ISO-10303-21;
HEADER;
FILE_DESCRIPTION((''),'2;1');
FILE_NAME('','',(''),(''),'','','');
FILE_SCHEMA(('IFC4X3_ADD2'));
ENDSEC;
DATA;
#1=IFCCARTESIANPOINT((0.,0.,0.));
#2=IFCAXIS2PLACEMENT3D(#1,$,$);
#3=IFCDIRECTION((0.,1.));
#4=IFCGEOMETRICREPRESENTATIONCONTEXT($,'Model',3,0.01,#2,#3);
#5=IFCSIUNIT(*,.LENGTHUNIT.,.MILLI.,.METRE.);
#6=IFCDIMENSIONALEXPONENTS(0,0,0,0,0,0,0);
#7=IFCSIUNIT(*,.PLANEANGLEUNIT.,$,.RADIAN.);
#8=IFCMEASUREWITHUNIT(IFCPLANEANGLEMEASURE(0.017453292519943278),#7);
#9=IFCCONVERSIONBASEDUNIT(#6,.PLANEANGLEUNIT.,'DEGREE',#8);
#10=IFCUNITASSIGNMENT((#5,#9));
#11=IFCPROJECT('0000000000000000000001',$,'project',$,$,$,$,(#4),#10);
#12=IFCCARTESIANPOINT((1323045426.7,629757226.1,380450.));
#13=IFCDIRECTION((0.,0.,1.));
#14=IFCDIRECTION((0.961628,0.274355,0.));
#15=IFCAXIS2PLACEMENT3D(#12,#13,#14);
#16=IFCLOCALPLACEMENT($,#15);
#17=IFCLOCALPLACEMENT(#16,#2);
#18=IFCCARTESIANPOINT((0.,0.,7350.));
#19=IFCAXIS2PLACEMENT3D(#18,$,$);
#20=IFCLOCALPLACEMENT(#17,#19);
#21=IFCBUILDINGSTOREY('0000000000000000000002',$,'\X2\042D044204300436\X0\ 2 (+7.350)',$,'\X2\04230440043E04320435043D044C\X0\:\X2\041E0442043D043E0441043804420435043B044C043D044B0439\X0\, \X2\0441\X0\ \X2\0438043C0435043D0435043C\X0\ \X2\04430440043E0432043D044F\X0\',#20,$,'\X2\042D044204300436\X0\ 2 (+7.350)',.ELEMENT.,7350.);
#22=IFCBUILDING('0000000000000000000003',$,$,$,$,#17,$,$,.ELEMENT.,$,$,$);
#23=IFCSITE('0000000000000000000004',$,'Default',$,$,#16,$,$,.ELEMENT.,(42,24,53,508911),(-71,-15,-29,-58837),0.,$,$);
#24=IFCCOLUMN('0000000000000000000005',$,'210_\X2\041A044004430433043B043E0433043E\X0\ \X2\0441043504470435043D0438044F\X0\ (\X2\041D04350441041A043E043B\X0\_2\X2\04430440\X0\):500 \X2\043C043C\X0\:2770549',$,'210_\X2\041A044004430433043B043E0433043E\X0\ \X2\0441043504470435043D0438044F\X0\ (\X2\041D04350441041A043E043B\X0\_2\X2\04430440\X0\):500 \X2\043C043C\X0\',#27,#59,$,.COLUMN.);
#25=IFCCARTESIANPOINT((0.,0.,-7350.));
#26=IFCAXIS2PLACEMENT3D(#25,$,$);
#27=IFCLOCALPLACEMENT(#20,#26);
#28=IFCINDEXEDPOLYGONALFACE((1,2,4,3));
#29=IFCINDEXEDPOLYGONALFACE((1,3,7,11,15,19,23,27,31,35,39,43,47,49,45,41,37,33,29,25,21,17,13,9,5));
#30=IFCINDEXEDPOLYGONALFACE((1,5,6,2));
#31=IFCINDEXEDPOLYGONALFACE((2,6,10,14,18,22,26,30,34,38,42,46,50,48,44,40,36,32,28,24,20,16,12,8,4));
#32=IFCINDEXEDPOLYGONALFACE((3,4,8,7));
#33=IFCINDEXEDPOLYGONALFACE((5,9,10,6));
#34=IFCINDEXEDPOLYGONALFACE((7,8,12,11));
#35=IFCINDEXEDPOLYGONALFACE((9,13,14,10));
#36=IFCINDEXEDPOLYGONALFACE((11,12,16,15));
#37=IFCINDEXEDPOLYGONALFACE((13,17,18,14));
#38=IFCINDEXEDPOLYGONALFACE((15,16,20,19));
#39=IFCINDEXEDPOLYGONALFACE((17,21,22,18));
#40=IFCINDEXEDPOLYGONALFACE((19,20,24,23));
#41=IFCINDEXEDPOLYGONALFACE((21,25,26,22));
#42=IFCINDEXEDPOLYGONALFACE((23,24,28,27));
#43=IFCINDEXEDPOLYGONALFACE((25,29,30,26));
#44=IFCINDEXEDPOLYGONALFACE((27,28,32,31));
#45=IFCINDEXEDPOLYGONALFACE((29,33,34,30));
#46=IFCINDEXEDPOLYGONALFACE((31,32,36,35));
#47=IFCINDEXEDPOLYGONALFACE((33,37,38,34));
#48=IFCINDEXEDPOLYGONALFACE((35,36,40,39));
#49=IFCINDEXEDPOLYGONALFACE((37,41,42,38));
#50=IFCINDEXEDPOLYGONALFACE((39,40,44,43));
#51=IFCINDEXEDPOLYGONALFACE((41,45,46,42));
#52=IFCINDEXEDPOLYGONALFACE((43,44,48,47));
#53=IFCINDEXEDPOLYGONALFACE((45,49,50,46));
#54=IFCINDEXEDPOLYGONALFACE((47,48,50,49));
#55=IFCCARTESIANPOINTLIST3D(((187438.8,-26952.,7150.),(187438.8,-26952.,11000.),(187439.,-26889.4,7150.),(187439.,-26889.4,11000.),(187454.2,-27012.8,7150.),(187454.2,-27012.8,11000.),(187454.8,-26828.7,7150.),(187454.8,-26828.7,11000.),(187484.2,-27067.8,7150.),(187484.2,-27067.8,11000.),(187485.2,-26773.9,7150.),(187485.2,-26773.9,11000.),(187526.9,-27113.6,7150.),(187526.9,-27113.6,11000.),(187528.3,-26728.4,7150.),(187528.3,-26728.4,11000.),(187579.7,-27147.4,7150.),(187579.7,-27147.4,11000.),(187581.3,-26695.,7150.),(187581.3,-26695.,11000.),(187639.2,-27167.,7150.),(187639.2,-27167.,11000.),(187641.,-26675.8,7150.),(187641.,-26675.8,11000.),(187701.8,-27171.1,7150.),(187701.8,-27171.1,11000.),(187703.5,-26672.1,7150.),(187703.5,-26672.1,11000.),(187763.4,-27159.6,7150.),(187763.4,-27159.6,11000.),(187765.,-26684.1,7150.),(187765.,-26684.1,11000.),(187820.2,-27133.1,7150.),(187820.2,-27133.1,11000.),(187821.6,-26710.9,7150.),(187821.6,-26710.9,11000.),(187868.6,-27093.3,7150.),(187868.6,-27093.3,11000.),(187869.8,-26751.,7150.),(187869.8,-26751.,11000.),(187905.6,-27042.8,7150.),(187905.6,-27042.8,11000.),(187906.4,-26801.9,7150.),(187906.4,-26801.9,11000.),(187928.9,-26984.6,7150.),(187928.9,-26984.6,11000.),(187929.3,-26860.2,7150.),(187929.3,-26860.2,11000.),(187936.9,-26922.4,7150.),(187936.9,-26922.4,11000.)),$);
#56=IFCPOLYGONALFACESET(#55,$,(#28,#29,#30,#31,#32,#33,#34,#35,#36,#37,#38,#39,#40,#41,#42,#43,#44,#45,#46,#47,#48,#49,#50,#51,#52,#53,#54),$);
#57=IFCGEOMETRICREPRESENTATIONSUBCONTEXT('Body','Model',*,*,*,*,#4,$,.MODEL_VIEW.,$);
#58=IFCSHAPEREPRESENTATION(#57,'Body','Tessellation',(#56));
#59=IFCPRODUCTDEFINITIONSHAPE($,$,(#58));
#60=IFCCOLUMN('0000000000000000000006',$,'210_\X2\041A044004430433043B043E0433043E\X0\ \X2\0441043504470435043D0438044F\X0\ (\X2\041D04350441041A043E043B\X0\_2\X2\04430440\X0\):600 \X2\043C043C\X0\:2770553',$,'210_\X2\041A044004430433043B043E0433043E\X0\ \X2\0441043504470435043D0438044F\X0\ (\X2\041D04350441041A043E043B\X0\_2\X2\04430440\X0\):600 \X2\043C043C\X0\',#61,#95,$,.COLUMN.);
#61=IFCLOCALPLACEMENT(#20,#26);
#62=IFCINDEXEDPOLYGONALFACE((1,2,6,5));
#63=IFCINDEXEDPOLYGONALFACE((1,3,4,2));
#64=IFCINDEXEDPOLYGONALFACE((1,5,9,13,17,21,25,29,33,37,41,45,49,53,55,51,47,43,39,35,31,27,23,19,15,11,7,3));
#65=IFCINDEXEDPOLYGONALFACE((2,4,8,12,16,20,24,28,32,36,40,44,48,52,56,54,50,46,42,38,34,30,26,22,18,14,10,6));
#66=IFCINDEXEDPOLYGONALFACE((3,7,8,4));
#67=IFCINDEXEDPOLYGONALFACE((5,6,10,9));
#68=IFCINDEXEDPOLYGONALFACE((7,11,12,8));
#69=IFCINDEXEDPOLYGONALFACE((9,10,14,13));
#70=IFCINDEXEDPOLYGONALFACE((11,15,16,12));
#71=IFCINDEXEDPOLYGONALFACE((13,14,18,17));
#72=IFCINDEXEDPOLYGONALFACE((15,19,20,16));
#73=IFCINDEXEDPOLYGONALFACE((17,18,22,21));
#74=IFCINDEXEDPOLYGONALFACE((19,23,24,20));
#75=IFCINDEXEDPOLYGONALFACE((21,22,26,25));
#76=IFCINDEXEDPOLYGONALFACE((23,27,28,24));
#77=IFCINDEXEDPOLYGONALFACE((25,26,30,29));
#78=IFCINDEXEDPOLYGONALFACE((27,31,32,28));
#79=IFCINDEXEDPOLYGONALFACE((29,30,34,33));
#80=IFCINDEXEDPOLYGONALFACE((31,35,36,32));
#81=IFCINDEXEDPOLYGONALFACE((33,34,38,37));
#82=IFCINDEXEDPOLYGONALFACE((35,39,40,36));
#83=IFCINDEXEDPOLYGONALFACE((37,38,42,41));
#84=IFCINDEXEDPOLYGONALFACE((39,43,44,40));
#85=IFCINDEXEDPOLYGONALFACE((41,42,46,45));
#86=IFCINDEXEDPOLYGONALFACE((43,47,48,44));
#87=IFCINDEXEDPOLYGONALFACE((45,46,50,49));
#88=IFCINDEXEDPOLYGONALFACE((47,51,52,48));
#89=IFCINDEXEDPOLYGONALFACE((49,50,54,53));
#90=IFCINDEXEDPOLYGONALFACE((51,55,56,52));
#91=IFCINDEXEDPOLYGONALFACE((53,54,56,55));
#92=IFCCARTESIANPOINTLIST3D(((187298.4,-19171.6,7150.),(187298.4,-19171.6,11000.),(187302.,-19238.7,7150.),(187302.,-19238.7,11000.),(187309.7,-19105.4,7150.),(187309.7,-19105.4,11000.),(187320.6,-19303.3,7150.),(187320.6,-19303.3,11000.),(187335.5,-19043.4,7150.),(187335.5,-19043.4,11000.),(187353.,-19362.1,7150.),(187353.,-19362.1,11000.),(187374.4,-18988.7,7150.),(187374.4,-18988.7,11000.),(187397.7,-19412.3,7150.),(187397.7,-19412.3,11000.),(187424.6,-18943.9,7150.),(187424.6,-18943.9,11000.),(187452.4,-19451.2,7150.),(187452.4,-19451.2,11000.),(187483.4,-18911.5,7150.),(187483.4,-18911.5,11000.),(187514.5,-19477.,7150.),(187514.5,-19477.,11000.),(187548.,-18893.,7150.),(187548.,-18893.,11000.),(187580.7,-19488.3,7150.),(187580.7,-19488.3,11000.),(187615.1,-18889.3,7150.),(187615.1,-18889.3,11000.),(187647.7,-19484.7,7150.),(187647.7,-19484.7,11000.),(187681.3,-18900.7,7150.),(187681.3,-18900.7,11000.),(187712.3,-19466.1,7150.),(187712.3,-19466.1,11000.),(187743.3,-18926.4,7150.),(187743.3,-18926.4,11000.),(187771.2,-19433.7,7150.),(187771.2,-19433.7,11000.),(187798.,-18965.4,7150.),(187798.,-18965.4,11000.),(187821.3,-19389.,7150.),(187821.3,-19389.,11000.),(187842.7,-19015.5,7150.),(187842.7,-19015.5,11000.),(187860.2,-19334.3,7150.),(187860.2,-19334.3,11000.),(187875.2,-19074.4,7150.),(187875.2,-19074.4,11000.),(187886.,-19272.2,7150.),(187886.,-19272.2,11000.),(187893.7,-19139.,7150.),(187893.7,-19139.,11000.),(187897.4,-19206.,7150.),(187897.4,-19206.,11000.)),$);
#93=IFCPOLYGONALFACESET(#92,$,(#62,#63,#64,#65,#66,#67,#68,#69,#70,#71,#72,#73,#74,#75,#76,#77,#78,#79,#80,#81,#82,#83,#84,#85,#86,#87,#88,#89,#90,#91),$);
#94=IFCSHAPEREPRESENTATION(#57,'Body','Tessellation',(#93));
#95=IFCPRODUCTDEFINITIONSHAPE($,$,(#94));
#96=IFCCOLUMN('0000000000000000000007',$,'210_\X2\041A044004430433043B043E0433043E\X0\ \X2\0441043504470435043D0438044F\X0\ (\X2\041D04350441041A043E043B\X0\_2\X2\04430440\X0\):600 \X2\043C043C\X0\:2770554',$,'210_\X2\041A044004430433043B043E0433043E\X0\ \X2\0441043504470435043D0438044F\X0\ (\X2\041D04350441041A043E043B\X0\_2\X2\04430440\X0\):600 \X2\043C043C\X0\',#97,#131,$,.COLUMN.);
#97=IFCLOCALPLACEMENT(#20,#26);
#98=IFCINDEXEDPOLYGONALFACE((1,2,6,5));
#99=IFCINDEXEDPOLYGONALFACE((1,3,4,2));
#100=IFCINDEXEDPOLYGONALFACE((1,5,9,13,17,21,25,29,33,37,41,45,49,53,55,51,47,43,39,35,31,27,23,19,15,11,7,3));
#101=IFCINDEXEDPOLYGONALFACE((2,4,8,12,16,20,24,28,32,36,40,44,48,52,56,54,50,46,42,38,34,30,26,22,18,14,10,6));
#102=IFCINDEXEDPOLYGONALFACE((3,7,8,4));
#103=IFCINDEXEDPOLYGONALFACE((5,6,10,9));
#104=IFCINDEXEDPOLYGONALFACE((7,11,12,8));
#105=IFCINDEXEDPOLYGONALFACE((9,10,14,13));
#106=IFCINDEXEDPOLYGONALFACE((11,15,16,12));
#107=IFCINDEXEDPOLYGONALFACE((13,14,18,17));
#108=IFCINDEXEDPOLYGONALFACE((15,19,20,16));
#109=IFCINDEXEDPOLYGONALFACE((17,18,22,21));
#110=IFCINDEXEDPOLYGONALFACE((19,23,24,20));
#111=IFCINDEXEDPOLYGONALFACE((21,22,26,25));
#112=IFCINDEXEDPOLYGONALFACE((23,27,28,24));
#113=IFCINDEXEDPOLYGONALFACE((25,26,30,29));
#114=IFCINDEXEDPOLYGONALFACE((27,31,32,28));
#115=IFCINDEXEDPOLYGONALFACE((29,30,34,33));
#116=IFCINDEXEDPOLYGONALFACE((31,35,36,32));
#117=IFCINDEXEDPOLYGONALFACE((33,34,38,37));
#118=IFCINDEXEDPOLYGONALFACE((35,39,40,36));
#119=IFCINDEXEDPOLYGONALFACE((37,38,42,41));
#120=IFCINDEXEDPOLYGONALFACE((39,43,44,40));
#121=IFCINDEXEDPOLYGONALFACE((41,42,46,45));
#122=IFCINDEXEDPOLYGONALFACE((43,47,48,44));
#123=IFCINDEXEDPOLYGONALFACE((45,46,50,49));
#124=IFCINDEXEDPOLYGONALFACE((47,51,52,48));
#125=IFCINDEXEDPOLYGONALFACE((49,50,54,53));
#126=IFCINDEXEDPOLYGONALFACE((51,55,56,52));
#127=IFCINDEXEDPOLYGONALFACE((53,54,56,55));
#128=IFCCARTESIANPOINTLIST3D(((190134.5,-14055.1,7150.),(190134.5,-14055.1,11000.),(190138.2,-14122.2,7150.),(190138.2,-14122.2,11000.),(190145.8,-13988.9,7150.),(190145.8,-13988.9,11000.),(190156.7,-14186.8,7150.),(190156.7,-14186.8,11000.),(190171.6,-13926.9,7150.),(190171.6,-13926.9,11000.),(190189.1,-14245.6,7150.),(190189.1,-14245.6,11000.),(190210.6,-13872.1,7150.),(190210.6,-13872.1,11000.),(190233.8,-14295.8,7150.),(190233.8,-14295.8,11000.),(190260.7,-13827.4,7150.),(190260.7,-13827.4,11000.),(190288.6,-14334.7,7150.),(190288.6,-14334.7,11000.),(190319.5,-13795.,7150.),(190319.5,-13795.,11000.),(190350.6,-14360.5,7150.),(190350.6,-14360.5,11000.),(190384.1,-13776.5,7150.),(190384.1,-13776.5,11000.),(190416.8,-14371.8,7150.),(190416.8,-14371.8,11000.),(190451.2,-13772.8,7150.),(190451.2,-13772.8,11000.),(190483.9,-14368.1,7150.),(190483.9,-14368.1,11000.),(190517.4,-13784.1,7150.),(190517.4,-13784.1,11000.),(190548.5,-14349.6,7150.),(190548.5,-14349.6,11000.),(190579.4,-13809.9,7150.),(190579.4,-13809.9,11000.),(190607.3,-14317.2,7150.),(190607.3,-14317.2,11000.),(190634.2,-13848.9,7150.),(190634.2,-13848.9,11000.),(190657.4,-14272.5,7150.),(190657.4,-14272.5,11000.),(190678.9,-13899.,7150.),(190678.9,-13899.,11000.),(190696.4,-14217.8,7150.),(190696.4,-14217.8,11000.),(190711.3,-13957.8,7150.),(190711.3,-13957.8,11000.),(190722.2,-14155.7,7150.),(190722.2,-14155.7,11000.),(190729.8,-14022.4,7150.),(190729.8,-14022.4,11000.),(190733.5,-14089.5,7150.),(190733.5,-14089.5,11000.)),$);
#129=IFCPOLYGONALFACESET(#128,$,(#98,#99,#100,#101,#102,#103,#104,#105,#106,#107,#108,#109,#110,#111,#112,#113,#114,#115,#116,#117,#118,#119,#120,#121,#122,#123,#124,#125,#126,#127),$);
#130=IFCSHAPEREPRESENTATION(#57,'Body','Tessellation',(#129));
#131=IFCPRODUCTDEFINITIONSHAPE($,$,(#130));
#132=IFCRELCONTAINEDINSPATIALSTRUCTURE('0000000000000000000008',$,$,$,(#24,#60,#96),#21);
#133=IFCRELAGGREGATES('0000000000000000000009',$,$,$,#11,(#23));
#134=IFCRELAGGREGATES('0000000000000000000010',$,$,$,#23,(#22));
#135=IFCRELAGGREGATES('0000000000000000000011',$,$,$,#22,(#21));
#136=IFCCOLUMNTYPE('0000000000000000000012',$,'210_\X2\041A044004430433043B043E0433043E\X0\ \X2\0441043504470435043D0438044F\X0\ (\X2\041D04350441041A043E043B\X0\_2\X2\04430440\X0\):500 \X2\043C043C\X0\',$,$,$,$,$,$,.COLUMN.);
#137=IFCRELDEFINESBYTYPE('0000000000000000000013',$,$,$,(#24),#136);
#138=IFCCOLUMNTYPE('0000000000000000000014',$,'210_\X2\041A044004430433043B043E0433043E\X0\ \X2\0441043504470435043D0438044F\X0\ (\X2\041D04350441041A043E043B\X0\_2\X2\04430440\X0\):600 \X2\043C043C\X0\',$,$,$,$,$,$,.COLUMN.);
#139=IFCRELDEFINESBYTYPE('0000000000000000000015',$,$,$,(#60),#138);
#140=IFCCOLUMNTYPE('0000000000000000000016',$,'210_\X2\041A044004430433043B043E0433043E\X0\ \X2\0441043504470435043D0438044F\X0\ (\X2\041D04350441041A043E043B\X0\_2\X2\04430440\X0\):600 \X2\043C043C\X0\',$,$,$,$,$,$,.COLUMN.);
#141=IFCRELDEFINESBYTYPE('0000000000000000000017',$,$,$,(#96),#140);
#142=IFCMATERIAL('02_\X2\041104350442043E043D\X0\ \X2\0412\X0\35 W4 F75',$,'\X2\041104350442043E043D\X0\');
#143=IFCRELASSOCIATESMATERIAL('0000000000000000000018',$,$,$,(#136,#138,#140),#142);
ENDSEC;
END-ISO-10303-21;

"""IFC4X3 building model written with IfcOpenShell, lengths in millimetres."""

from ifc_helpers import new_model, entity, si_unit, converted_unit, direction, frame, frame_2d, origin, origin_2d_with_axis, place, context, subcontext, project, spatial, circle, extrude, source, transform, mapped, material, material_profile, profile_set, type_object, type_shapes, element, save


model = new_model("IFC4X3")

# Units and contexts
model_context = context("Model", 3, precision=0.01, world=origin(), true_north=direction((0.0, 1.0)))
body_context = subcontext(model_context, "Body", "Model", "MODEL_VIEW")
ifc_project = project(units=[si_unit("LENGTHUNIT", "METRE", prefix="MILLI"), converted_unit("PLANEANGLEUNIT", "DEGREE", entity("IfcPlaneAngleMeasure", 0.017453292519943278), si_unit("PLANEANGLEUNIT", "RADIAN"), dimensions=[0, 0, 0, 0, 0, 0, 0])], contexts=[model_context])

# Site, building, storey
site_placement = place(None, frame((1323045426.7, 629757226.1, 380450.0), z_axis=(0.0, 0.0, 1.0), x_axis=(0.961628, 0.274355, 0.0)))
site = spatial("IfcSite", under=ifc_project, at=site_placement, Name="Default", CompositionType="ELEMENT", RefLatitude=(42, 24, 53, 508911), RefLongitude=(-71, -15, -29, -58837), RefElevation=0.0)
building_placement = place(site_placement, origin())
building = spatial("IfcBuilding", under=site, at=building_placement, CompositionType="ELEMENT")
storey_placement = place(building_placement, frame((0.0, 0.0, 7350.0)))
storey = spatial("IfcBuildingStorey", under=building, at=storey_placement, Name="Этаж 2 (+7.350)", ObjectType="Уровень:Относительный, с именем уровня", LongName="Этаж 2 (+7.350)", CompositionType="ELEMENT", Elevation=7350.0)

# Columns
ifc_material = material(Name="02_Бетон В35 W4 F75", Category="Бетон")
ifc_material_profile_1 = material_profile(ifc_material, circle(Radius=250.0, at=frame_2d((0.0, 0.0), x_axis=(1.0, 0.0))), Name="500 мм")
ifc_profile_set_1 = profile_set([ifc_material_profile_1], Name="500 мм")
ifc_material_profile_2 = material_profile(ifc_material, circle(Radius=300.0, at=origin_2d_with_axis()), Name="600 мм")
ifc_profile_set_2 = profile_set([ifc_material_profile_2], Name="600 мм")
column_type_1 = type_object("IfcColumnType", Name="210_Круглого сечения (НесКол_2ур):500 мм", PredefinedType="COLUMN", material=ifc_profile_set_1)
shared_shape_1 = source(origin(), body_context, "Body", "SweptSolid", [
    extrude(circle(Radius=250.0, at=origin_2d_with_axis()), frame((187686.9, -26921.5, 7150.0), z_axis=(0.0, 0.0, 1.0), x_axis=(0.87462, -0.48481, 0.0)), (0.0, 0.0, 1.0), 3850.0),
])
type_shapes(column_type_1, [shared_shape_1])
column_1_placement = place(storey_placement, frame((0.0, 0.0, -7350.0)))
element("IfcColumn", 1, at=column_1_placement, inside=storey, type_object=column_type_1, Name="210_Круглого сечения (НесКол_2ур):500 мм:2770549", ObjectType="210_Круглого сечения (НесКол_2ур):500 мм", PredefinedType="COLUMN", context=body_context, shape_type="MappedRepresentation", body=[
    mapped(shared_shape_1, transform((0.0, 0.0, 0.0), scale=1.0)),
])
column_type_2 = type_object("IfcColumnType", Name="210_Круглого сечения (НесКол_2ур):600 мм", PredefinedType="COLUMN", material=ifc_profile_set_2)
shared_shape_2 = source(origin(), body_context, "Body", "SweptSolid", [
    extrude(circle(Radius=300.0, at=origin_2d_with_axis()), frame((187597.9, -19188.8, 7150.0), z_axis=(0.0, 0.0, 1.0), x_axis=(0.87462, -0.48481, 0.0)), (0.0, 0.0, 1.0), 3850.0),
])
type_shapes(column_type_2, [shared_shape_2])
column_2_placement = place(storey_placement, frame((0.0, 0.0, -7350.0)))
element("IfcColumn", 2, at=column_2_placement, inside=storey, type_object=column_type_2, Name="210_Круглого сечения (НесКол_2ур):600 мм:2770553", ObjectType="210_Круглого сечения (НесКол_2ур):600 мм", PredefinedType="COLUMN", context=body_context, shape_type="MappedRepresentation", body=[
    mapped(shared_shape_2, transform((0.0, 0.0, 0.0), scale=1.0)),
])
column_type_3 = type_object("IfcColumnType", Name="210_Круглого сечения (НесКол_2ур):600 мм", PredefinedType="COLUMN", material=ifc_profile_set_2)
shared_shape_3 = source(origin(), body_context, "Body", "SweptSolid", [
    extrude(circle(Radius=300.0, at=frame_2d((0.0, 0.0), x_axis=(1.0, 0.0))), frame((190434.0, -14072.3, 7150.0), z_axis=(0.0, 0.0, 1.0), x_axis=(0.87462, -0.48481, 0.0)), (0.0, 0.0, 1.0), 3850.0),
])
type_shapes(column_type_3, [shared_shape_3])
column_3_placement = place(storey_placement, frame((0.0, 0.0, -7350.0)))
element("IfcColumn", 3, at=column_3_placement, inside=storey, type_object=column_type_3, Name="210_Круглого сечения (НесКол_2ур):600 мм:2770554", ObjectType="210_Круглого сечения (НесКол_2ур):600 мм", PredefinedType="COLUMN", context=body_context, shape_type="MappedRepresentation", body=[
    mapped(shared_shape_3, transform((0.0, 0.0, 0.0), scale=1.0)),
])

save(model, "model.ifc")
